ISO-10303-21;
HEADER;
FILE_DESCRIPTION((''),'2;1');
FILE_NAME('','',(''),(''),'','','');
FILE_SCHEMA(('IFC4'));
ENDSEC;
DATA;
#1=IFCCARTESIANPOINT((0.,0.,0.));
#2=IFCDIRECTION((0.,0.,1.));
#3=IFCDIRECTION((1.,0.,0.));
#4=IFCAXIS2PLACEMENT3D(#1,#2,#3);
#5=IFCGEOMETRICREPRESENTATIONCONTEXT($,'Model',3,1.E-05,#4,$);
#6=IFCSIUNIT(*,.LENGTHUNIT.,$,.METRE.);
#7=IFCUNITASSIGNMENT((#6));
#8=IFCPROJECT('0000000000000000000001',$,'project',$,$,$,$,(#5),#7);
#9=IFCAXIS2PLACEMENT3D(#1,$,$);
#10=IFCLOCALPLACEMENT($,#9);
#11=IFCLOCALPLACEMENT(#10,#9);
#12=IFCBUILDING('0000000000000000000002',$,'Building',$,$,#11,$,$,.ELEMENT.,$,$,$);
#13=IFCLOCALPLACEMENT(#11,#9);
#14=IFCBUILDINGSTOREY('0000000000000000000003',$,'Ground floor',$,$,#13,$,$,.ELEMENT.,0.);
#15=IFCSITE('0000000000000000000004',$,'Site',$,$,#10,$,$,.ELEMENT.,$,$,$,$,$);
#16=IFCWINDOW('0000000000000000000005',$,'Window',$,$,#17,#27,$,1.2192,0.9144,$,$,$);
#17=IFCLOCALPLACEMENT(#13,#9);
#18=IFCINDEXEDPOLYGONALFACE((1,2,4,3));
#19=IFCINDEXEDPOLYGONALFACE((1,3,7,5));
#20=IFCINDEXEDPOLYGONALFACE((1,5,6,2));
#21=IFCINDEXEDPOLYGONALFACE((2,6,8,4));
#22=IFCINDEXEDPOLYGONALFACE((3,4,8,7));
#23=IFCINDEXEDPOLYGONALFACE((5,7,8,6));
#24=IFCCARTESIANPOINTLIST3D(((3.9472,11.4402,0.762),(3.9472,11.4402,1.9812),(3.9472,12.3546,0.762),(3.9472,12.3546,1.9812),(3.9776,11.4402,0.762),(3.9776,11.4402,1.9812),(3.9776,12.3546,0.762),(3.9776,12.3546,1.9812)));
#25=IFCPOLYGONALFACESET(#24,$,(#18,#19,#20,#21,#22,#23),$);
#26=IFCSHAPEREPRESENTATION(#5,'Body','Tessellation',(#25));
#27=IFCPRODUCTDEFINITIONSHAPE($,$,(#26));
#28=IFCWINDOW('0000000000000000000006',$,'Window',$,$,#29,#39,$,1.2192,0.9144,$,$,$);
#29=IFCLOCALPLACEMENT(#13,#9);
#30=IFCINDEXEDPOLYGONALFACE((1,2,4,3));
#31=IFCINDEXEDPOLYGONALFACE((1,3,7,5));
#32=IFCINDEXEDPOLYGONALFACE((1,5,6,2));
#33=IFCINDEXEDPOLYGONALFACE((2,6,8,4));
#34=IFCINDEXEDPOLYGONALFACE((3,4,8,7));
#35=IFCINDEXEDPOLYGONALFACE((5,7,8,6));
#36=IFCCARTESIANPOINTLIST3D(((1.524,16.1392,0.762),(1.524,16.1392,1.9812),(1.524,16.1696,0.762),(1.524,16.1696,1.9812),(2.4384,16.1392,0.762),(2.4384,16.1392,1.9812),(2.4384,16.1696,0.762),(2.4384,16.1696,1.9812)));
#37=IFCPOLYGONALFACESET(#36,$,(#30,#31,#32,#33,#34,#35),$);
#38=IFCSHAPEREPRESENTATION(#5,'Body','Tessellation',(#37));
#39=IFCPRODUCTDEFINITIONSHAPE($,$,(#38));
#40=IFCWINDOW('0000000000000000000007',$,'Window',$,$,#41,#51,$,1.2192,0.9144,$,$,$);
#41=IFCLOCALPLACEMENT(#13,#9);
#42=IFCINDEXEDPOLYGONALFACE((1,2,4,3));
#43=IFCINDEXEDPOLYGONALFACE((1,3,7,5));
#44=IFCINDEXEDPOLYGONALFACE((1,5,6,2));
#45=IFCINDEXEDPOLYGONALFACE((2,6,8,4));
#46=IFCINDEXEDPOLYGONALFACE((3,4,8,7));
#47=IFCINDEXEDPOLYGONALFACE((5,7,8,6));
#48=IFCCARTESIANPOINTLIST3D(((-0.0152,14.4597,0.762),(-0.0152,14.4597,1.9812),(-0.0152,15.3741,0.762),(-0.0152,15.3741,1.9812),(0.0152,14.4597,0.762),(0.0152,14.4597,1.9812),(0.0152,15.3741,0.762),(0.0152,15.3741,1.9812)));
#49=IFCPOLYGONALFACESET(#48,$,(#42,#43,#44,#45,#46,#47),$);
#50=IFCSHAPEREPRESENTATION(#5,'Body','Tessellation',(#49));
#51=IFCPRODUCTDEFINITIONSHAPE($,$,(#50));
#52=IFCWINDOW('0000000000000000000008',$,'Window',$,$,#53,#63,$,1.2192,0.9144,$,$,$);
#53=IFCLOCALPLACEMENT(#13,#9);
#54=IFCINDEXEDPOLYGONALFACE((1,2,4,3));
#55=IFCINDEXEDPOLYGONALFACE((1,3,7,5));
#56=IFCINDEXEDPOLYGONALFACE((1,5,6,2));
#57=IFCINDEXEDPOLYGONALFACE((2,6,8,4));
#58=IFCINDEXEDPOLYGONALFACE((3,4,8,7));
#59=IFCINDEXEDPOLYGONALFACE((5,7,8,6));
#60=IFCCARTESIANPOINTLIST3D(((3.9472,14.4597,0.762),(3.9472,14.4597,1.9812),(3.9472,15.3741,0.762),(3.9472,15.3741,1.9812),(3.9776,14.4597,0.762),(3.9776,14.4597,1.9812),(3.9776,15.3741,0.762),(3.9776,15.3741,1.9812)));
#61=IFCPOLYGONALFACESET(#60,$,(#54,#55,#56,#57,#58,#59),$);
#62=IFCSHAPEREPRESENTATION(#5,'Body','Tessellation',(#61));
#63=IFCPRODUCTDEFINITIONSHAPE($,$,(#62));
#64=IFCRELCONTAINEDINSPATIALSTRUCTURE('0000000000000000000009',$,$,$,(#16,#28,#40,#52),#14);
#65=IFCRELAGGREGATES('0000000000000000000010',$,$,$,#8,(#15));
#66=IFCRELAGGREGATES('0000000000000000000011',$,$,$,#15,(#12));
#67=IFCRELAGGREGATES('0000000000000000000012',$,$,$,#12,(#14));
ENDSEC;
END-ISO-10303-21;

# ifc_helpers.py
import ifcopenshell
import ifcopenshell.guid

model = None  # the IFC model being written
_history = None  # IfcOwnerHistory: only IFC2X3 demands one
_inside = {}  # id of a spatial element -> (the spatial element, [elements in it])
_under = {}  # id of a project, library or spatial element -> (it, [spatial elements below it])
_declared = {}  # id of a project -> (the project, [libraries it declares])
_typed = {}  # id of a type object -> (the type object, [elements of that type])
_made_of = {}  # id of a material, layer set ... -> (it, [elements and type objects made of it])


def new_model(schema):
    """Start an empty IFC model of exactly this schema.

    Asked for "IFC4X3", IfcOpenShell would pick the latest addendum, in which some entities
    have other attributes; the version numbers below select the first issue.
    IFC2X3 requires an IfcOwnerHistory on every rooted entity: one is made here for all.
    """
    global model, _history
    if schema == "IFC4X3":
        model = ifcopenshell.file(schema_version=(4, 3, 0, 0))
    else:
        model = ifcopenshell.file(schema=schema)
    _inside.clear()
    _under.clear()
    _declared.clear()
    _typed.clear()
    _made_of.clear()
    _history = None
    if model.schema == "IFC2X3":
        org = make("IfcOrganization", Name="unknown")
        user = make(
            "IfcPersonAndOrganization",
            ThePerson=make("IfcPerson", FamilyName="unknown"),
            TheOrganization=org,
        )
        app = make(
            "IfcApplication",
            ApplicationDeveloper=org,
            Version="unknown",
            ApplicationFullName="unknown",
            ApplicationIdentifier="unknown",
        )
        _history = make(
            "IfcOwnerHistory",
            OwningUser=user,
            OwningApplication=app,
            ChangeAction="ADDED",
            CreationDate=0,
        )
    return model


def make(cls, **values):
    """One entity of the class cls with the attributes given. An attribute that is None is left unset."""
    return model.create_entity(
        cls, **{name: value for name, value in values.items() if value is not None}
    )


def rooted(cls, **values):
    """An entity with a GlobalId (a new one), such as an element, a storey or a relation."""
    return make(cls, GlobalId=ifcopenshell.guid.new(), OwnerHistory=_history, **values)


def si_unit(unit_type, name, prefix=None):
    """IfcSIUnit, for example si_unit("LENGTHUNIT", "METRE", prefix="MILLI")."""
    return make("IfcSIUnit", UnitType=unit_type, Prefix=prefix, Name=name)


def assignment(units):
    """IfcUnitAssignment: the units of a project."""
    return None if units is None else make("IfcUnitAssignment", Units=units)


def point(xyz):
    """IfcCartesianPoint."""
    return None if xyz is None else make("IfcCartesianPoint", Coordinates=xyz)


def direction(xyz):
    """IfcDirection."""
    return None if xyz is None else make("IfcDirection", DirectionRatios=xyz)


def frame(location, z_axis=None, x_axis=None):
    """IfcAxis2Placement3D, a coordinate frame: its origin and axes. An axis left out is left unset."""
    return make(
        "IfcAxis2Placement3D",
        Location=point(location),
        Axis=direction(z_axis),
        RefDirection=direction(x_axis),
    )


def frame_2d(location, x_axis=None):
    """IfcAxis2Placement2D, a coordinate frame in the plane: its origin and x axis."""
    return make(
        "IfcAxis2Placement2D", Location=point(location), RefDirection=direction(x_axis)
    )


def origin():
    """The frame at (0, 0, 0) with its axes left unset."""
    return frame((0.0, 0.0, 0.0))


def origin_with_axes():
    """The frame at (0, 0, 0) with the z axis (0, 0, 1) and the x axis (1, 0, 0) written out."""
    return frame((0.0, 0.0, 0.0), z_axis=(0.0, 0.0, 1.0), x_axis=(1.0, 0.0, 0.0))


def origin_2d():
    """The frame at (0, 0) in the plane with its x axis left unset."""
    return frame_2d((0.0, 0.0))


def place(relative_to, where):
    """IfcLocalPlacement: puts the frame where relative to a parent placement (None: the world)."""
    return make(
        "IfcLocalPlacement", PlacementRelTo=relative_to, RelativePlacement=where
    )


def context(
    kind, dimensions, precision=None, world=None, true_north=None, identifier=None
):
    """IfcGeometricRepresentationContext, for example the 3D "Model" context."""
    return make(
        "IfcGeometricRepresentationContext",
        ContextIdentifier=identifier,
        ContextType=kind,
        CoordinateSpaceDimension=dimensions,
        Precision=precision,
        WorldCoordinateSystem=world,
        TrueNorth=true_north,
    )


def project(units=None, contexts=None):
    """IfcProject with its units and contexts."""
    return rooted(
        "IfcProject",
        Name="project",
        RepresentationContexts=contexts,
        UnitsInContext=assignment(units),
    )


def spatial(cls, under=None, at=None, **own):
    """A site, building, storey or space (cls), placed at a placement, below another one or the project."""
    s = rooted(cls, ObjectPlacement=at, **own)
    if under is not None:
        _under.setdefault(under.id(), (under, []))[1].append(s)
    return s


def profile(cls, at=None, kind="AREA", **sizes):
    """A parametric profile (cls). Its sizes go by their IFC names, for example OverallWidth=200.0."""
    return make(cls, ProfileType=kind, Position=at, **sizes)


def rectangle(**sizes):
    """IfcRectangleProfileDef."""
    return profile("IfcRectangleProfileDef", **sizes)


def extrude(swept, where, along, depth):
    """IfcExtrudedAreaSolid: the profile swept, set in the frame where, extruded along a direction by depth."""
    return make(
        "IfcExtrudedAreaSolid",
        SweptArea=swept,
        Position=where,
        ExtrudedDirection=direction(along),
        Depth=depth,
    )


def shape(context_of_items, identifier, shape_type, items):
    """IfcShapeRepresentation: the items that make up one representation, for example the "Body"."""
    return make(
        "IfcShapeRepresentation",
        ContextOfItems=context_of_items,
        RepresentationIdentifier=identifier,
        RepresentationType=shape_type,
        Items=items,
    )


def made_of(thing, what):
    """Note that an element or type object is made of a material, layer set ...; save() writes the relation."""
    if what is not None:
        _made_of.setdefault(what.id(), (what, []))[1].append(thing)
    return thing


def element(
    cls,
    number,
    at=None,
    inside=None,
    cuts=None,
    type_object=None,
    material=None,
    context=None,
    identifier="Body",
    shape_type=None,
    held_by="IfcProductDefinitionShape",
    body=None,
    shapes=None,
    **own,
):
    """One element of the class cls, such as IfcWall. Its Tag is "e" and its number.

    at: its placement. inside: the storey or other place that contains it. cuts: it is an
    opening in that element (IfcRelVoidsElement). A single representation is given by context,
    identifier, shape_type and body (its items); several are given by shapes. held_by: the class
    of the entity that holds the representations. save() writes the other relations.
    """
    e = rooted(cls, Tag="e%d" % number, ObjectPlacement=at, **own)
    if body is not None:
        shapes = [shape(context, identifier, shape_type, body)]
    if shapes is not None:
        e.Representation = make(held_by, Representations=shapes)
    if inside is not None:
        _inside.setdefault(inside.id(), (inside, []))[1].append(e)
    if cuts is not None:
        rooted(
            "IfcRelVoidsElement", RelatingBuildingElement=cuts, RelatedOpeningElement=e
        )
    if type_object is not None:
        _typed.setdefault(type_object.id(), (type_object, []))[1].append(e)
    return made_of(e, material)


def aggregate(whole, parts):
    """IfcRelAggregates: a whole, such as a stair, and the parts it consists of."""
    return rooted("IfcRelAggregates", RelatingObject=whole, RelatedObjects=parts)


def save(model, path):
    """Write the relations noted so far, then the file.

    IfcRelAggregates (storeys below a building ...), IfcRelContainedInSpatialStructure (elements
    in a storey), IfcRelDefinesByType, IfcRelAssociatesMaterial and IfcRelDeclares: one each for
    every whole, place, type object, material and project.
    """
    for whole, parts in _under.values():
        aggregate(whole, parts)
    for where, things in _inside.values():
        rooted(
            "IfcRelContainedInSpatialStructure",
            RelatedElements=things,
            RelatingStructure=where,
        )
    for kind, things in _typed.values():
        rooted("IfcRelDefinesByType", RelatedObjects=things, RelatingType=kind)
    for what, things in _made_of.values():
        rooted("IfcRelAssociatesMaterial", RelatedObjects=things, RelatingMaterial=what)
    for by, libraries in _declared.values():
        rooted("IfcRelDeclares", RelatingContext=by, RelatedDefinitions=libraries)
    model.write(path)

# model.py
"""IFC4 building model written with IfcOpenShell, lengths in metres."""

from ifc_helpers import new_model, si_unit, frame, origin, origin_with_axes, origin_2d, place, context, project, spatial, rectangle, extrude, element, save


model = new_model("IFC4")

# Units and contexts
model_context = context("Model", 3, precision=1e-05, world=origin_with_axes())
ifc_project = project(units=[si_unit("LENGTHUNIT", "METRE")], contexts=[model_context])

# Site, building, storey
site_placement = place(None, origin())
site = spatial("IfcSite", under=ifc_project, at=site_placement, Name="Site", CompositionType="ELEMENT")
building_placement = place(site_placement, origin())
building = spatial("IfcBuilding", under=site, at=building_placement, Name="Building", CompositionType="ELEMENT")
storey_placement = place(building_placement, origin())
storey = spatial("IfcBuildingStorey", under=building, at=storey_placement, Name="Ground floor", CompositionType="ELEMENT", Elevation=0.0)

# Windows
for number, where, x_axis, name in (
    (1, (3.9624, 11.8974, 0.762), (0.0, 1.0, 0.0), "Window"),
    (2, (1.9812, 16.1544, 0.762), (1.0, 0.0, 0.0), "Window"),
    (3, (0.0, 14.9169, 0.762), (0.0, 1.0, 0.0), "Window"),
    (4, (3.9624, 14.9169, 0.762), (0.0, 1.0, 0.0), "Window"),
):
    element("IfcWindow", number, at=place(storey_placement, frame(where, x_axis=x_axis)), inside=storey, Name=name, OverallHeight=1.2192, OverallWidth=0.9144, context=model_context, shape_type="SweptSolid", body=[
        extrude(rectangle(XDim=0.9144, YDim=0.0305, at=origin_2d()), origin(), (0.0, 0.0, 1.0), 1.2192),
    ])

save(model, "model.ifc")
